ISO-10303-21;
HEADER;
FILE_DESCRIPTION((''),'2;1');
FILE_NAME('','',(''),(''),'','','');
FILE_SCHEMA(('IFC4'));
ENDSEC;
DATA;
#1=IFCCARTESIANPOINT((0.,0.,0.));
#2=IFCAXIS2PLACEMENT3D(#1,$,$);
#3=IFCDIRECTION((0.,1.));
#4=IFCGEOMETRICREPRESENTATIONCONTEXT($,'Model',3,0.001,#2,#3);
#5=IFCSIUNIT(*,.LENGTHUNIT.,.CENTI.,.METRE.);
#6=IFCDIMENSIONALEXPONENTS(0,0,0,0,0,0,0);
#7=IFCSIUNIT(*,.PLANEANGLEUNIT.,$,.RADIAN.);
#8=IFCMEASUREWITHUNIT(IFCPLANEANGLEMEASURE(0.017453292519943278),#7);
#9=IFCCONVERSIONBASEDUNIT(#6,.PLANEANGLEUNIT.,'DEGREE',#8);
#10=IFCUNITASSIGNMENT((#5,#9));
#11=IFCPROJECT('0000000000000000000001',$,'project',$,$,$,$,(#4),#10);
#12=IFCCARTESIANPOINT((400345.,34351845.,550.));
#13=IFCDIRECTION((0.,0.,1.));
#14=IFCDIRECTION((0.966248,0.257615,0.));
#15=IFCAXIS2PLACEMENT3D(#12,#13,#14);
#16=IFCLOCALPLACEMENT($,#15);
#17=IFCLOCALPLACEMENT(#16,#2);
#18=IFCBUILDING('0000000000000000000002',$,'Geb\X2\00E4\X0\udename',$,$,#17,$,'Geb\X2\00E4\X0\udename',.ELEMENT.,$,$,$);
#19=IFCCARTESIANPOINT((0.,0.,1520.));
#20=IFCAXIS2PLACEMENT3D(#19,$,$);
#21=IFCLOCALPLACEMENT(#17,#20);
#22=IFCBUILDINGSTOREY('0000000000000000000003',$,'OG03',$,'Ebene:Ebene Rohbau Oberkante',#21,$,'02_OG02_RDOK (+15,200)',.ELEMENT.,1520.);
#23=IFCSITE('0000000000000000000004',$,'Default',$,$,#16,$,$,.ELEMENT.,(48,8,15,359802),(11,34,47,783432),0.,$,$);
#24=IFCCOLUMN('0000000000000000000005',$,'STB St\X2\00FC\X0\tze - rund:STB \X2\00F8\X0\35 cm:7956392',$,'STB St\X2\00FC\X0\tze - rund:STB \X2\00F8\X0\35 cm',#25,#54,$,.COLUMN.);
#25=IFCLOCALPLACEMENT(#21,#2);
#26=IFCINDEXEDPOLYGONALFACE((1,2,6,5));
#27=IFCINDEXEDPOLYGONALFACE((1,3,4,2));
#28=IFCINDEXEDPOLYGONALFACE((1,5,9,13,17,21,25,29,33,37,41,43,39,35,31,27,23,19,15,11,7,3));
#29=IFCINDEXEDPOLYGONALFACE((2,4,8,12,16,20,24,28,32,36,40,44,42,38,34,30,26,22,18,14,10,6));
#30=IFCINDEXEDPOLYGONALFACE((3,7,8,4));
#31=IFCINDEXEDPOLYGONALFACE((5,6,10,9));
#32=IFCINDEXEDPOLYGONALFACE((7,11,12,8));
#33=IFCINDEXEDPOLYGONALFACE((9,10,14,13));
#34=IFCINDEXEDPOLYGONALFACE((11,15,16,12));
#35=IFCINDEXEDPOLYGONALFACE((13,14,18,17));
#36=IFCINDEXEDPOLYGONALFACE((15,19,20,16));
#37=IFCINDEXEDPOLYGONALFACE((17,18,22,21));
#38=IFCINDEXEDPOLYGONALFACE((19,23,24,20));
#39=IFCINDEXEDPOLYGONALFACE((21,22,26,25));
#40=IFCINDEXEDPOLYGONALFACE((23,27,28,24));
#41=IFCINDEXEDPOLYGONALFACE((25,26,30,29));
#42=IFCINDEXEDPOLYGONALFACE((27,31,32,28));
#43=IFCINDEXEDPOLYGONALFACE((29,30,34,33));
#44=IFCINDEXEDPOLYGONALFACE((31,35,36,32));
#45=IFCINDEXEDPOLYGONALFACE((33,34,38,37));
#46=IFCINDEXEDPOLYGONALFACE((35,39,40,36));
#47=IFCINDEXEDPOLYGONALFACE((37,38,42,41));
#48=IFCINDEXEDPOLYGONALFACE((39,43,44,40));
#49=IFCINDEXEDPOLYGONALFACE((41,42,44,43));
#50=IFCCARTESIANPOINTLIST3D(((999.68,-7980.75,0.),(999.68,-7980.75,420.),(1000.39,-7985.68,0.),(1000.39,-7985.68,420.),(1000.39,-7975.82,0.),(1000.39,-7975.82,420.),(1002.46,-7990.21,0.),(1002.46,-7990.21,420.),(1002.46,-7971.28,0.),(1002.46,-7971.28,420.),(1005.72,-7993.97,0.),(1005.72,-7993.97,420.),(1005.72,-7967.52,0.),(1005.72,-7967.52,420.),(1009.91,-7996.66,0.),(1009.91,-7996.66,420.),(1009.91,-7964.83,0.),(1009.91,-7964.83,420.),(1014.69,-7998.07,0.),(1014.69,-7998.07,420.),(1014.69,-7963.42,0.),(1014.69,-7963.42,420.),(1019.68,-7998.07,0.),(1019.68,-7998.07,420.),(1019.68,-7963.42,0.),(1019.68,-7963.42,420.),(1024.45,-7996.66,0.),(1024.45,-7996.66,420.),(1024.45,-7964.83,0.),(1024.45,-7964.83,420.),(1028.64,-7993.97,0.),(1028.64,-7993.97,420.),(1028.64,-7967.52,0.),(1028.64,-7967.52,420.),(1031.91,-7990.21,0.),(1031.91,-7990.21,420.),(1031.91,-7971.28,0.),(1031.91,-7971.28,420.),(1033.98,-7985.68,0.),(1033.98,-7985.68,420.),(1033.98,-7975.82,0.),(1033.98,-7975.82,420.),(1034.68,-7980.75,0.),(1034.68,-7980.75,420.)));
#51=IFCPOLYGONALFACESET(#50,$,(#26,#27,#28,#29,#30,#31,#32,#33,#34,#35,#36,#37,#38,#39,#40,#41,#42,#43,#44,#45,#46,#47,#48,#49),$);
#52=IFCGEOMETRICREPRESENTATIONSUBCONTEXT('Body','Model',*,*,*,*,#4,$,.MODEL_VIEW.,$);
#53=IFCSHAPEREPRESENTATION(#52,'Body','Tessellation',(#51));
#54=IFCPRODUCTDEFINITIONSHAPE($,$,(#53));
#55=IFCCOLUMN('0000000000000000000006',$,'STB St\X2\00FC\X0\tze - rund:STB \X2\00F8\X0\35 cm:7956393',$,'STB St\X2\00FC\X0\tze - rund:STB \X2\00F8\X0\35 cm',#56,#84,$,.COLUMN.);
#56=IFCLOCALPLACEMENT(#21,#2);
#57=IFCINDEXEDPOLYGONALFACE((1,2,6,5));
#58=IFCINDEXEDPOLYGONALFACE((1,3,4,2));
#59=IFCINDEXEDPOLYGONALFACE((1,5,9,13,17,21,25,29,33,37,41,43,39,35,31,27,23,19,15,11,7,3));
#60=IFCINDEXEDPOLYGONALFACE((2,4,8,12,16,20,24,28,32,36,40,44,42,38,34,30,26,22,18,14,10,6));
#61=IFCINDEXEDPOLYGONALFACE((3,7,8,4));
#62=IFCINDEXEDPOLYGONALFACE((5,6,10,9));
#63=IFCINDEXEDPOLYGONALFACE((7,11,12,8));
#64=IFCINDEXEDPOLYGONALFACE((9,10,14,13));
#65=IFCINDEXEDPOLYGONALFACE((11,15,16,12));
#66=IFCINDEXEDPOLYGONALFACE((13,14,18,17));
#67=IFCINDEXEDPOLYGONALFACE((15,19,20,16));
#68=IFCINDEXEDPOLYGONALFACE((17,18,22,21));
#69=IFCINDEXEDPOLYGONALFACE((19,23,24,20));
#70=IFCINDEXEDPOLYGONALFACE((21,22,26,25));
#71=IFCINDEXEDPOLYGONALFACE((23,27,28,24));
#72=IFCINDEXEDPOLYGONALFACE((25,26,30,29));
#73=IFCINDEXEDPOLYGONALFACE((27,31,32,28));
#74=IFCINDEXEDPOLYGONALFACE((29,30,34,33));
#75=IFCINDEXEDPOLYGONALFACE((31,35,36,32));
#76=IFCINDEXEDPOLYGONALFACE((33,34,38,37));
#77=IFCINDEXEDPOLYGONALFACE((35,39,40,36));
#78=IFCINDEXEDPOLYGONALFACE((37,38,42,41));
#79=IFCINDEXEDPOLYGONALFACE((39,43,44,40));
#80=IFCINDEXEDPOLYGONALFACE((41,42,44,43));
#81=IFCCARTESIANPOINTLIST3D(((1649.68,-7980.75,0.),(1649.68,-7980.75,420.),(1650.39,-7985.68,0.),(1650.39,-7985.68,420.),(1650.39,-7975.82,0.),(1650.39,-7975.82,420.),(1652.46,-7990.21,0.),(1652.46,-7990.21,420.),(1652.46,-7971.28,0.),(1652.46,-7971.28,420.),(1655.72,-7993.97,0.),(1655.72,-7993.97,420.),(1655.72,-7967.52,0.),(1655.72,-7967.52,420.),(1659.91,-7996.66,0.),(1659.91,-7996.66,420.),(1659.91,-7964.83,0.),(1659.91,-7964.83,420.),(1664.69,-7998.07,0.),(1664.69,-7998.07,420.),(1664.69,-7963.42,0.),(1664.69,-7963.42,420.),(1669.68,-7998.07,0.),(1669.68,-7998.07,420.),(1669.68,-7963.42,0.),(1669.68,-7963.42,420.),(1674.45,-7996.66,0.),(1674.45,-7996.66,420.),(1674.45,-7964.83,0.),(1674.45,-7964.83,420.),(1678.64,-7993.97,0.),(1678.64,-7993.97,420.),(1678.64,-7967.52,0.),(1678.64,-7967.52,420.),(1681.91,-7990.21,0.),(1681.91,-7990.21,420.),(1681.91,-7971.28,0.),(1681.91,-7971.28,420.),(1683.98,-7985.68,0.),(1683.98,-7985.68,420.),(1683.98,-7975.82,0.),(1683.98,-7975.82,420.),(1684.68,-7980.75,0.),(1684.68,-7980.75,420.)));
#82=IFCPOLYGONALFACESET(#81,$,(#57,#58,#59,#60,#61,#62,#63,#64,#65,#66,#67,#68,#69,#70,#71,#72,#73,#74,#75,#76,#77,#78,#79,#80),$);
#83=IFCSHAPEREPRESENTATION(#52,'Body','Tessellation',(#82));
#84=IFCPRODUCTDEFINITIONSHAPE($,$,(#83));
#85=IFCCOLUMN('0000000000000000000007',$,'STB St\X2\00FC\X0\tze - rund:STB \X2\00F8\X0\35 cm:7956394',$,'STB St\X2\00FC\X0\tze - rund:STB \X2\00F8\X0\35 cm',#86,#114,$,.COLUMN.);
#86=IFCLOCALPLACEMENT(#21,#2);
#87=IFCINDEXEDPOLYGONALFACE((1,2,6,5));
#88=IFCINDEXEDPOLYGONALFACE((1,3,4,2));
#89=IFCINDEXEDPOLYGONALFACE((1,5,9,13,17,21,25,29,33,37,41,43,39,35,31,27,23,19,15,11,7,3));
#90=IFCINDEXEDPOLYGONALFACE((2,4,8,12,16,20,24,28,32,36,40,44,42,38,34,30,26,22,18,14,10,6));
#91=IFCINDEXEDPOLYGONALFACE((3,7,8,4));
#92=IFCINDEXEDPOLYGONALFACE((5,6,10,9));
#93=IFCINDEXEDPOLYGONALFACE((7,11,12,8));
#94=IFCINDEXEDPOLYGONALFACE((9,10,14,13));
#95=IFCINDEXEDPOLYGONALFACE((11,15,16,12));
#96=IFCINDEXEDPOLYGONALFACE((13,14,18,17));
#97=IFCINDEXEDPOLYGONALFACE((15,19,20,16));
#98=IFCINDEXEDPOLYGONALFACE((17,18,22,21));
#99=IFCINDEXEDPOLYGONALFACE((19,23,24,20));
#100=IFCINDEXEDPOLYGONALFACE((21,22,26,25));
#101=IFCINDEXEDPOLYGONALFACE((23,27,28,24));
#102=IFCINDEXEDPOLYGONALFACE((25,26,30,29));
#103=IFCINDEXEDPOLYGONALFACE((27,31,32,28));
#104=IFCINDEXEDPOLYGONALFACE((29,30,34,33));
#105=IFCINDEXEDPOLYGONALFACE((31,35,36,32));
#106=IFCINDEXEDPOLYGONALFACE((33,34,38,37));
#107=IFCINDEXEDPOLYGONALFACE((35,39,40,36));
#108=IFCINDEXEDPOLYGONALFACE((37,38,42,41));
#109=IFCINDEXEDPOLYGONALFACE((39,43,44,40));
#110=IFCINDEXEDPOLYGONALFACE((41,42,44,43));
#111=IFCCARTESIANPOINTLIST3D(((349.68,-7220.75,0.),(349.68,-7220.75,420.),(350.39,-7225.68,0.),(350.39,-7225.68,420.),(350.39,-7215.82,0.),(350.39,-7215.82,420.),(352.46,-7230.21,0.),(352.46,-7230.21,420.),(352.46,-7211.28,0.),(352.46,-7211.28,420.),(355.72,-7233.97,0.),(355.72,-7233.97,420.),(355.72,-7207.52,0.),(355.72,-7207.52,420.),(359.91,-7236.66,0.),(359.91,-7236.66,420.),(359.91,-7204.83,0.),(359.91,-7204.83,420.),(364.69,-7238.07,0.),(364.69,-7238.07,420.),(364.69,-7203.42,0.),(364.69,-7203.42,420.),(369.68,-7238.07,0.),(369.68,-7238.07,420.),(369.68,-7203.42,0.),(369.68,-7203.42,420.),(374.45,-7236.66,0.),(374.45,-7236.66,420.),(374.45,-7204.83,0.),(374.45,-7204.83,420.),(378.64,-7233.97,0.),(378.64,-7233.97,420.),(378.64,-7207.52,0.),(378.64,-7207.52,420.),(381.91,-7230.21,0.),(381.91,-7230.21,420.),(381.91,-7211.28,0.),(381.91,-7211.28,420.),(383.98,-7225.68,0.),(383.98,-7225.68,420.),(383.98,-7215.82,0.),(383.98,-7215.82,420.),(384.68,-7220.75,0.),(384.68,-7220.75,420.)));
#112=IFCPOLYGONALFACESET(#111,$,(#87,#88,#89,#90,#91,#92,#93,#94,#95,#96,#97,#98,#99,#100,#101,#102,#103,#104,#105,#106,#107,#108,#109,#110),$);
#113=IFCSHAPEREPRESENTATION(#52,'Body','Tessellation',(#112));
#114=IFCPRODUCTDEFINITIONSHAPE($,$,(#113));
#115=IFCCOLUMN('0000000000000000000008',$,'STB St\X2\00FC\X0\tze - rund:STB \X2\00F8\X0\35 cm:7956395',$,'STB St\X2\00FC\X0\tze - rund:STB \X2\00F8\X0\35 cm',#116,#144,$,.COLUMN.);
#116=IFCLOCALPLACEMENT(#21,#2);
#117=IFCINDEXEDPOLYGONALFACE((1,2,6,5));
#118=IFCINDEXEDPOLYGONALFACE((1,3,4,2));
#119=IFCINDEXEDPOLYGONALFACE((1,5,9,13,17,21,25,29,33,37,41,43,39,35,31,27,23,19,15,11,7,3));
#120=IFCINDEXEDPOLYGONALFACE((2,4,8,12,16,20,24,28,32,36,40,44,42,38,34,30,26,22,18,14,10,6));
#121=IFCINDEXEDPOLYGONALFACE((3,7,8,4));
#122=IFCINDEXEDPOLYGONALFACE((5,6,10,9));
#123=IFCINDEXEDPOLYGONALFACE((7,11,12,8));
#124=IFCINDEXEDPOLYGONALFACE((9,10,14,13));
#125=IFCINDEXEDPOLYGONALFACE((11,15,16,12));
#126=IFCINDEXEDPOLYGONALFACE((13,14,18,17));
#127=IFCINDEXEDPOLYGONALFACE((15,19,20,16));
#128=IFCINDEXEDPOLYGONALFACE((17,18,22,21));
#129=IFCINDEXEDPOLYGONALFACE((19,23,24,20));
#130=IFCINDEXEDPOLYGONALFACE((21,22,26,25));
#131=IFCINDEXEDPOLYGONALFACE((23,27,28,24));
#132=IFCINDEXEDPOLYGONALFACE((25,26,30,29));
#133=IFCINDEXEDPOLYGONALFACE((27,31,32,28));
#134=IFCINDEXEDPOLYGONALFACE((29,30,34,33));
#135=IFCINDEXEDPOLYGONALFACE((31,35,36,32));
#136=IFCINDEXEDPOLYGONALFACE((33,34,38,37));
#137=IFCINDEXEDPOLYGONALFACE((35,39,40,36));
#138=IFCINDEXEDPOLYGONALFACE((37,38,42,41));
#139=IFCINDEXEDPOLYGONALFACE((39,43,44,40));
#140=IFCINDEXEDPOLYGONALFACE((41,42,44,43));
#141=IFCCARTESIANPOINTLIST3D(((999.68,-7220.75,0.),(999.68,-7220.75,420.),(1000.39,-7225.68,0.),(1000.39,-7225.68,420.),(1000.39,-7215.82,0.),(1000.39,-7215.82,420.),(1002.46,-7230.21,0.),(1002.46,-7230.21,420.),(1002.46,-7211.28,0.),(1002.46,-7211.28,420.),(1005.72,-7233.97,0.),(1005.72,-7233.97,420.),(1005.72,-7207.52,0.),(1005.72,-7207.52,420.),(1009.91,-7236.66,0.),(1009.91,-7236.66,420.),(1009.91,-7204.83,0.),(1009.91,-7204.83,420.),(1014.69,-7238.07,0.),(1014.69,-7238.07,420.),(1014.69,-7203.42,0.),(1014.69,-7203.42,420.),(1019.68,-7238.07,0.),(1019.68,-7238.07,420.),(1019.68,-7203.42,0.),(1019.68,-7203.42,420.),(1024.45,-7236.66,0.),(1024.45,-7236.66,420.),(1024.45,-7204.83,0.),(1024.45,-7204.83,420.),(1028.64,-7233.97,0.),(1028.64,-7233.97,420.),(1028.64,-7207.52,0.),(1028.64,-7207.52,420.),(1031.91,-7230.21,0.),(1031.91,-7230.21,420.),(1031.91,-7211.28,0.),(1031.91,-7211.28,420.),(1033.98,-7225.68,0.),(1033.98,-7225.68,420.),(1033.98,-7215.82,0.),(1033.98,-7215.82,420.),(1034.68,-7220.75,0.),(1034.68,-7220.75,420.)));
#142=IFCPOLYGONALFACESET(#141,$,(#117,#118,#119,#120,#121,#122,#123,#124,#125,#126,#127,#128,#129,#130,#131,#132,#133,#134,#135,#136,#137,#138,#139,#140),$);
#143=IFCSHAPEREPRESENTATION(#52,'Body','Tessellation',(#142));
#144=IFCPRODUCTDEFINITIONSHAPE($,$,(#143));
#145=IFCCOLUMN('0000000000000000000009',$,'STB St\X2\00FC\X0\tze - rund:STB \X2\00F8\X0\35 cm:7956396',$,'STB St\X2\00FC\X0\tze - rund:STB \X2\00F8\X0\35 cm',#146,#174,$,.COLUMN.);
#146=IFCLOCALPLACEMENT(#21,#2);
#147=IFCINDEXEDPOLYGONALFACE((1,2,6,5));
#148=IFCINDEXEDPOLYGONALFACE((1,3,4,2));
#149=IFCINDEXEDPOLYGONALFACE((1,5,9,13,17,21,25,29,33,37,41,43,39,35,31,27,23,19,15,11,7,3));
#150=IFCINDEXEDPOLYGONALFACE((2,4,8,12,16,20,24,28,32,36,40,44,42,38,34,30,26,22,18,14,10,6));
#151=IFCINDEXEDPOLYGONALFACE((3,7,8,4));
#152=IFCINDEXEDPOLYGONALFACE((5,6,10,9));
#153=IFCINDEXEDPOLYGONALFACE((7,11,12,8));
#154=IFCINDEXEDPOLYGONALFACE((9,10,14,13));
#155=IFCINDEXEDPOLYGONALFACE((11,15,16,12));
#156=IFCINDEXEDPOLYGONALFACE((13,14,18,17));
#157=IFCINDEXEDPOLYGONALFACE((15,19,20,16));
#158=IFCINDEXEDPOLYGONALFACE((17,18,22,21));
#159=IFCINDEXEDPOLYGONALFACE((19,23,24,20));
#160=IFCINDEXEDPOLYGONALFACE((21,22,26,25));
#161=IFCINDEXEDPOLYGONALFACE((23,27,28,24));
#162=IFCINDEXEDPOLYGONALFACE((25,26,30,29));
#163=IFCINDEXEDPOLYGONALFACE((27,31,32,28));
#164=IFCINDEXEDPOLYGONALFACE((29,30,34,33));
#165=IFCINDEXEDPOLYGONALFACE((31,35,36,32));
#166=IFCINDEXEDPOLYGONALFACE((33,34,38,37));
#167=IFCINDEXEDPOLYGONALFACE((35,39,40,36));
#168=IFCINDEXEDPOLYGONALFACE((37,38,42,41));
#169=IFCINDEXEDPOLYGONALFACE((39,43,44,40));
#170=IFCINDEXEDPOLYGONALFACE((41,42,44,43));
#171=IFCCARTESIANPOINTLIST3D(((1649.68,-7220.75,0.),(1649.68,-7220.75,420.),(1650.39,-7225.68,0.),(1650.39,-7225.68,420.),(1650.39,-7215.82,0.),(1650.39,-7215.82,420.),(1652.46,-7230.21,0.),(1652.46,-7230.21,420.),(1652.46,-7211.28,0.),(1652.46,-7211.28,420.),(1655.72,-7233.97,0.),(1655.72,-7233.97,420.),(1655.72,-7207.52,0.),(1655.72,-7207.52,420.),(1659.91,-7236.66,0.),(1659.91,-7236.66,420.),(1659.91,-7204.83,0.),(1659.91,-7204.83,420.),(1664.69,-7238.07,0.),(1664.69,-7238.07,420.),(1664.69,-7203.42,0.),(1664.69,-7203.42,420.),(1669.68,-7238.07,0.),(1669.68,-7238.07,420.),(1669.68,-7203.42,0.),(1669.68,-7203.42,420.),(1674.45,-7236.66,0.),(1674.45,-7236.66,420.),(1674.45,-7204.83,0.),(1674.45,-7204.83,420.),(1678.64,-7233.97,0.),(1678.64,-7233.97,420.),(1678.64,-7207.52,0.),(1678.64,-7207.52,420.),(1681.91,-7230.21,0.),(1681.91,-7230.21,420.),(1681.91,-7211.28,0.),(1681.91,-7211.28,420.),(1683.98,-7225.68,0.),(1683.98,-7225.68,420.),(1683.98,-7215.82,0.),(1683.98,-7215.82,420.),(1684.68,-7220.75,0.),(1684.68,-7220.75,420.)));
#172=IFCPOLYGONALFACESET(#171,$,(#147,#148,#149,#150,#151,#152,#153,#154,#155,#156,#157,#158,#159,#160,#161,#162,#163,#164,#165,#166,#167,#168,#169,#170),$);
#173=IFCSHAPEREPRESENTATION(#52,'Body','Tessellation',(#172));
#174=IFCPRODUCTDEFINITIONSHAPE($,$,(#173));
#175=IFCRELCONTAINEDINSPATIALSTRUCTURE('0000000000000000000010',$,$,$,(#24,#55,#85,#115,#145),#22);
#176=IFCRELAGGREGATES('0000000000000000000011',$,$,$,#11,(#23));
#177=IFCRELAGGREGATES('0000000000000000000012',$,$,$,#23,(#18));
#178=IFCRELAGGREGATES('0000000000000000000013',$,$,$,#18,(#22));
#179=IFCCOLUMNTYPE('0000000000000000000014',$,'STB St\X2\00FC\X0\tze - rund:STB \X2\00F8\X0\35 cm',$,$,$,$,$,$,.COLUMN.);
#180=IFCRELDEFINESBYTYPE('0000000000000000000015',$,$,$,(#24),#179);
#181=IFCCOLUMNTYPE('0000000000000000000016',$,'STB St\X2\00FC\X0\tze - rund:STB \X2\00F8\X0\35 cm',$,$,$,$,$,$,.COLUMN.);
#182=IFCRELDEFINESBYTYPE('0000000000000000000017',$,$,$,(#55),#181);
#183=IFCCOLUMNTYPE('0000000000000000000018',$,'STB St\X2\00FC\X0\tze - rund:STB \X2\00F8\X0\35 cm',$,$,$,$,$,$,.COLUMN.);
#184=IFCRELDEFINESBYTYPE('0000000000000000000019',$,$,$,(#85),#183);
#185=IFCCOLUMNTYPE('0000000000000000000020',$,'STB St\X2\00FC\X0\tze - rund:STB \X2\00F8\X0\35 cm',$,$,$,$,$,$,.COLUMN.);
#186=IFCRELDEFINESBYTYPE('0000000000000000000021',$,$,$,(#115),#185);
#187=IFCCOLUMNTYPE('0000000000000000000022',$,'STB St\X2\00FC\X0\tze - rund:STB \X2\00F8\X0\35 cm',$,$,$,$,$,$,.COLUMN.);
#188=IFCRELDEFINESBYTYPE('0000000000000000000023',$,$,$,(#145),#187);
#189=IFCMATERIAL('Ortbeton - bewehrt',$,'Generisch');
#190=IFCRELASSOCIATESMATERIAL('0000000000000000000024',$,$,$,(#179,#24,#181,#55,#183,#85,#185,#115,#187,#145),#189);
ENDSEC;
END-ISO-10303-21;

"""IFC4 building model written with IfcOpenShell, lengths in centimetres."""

from ifc_helpers import new_model, entity, si_unit, converted_unit, direction, frame, origin, place, context, subcontext, project, spatial, arc, indexed_curve, outline, extrude, source, transform, mapped, material, type_object, type_shapes, element, save


model = new_model("IFC4")

# Units and contexts
model_context = context("Model", 3, precision=0.001, world=origin(), true_north=direction((0.0, 1.0)))
body_context = subcontext(model_context, "Body", "Model", "MODEL_VIEW")
ifc_project = project(units=[si_unit("LENGTHUNIT", "METRE", prefix="CENTI"), converted_unit("PLANEANGLEUNIT", "DEGREE", entity("IfcPlaneAngleMeasure", 0.017453292519943278), si_unit("PLANEANGLEUNIT", "RADIAN"), dimensions=[0, 0, 0, 0, 0, 0, 0])], contexts=[model_context])

# Site, building, storey
site_placement = place(None, frame((400345.0, 34351845.0, 550.0), z_axis=(0.0, 0.0, 1.0), x_axis=(0.966248, 0.257615, 0.0)))
site = spatial("IfcSite", under=ifc_project, at=site_placement, Name="Default", CompositionType="ELEMENT", RefLatitude=(48, 8, 15, 359802), RefLongitude=(11, 34, 47, 783432), RefElevation=0.0)
building_placement = place(site_placement, origin())
building = spatial("IfcBuilding", under=site, at=building_placement, Name="Gebäudename", LongName="Gebäudename", CompositionType="ELEMENT")
storey_placement = place(building_placement, frame((0.0, 0.0, 1520.0)))
storey = spatial("IfcBuildingStorey", under=building, at=storey_placement, Name="OG03", ObjectType="Ebene:Ebene Rohbau Oberkante", LongName="02_OG02_RDOK (+15,200)", CompositionType="ELEMENT", Elevation=1520.0)

# Columns
ifc_material = material(Name="Ortbeton - bewehrt", Category="Generisch")
column_type_1 = type_object("IfcColumnType", Name="STB Stütze - rund:STB ø35 cm", PredefinedType="COLUMN", material=ifc_material)
shared_shape_1 = source(origin(), body_context, "Body", "SweptSolid", [
    extrude(outline(indexed_curve([(-17.5, 0.0), (0.0, -17.5), (17.5, 0.0), (0.0, 17.5)], segments=[arc(1, 2, 3), arc(3, 4, 1)], self_intersect=False)), frame((1017.18, -7980.75, 1520.0)), (0.0, 0.0, 1.0), 420.0),
])
type_shapes(column_type_1, [shared_shape_1])
column_1_placement = place(storey_placement, frame((0.0, 0.0, -1520.0)))
element("IfcColumn", 1, at=column_1_placement, inside=storey, type_object=column_type_1, material=ifc_material, Name="STB Stütze - rund:STB ø35 cm:7956392", ObjectType="STB Stütze - rund:STB ø35 cm", PredefinedType="COLUMN", context=body_context, shape_type="MappedRepresentation", body=[
    mapped(shared_shape_1, transform((0.0, 0.0, 0.0), scale=1.0)),
])
column_type_2 = type_object("IfcColumnType", Name="STB Stütze - rund:STB ø35 cm", PredefinedType="COLUMN", material=ifc_material)
shared_shape_2 = source(origin(), body_context, "Body", "SweptSolid", [
    extrude(outline(indexed_curve([(-17.5, 0.0), (0.0, -17.5), (17.5, 0.0), (0.0, 17.5)], segments=[arc(1, 2, 3), arc(3, 4, 1)], self_intersect=False)), frame((1667.18, -7980.75, 1520.0)), (0.0, 0.0, 1.0), 420.0),
])
type_shapes(column_type_2, [shared_shape_2])
column_2_placement = place(storey_placement, frame((0.0, 0.0, -1520.0)))
element("IfcColumn", 2, at=column_2_placement, inside=storey, type_object=column_type_2, material=ifc_material, Name="STB Stütze - rund:STB ø35 cm:7956393", ObjectType="STB Stütze - rund:STB ø35 cm", PredefinedType="COLUMN", context=body_context, shape_type="MappedRepresentation", body=[
    mapped(shared_shape_2, transform((0.0, 0.0, 0.0), scale=1.0)),
])
column_type_3 = type_object("IfcColumnType", Name="STB Stütze - rund:STB ø35 cm", PredefinedType="COLUMN", material=ifc_material)
shared_shape_3 = source(origin(), body_context, "Body", "SweptSolid", [
    extrude(outline(indexed_curve([(-17.5, 0.0), (0.0, -17.5), (17.5, 0.0), (0.0, 17.5)], segments=[arc(1, 2, 3), arc(3, 4, 1)], self_intersect=False)), frame((367.18, -7220.75, 1520.0)), (0.0, 0.0, 1.0), 420.0),
])
type_shapes(column_type_3, [shared_shape_3])
column_3_placement = place(storey_placement, frame((0.0, 0.0, -1520.0)))
element("IfcColumn", 3, at=column_3_placement, inside=storey, type_object=column_type_3, material=ifc_material, Name="STB Stütze - rund:STB ø35 cm:7956394", ObjectType="STB Stütze - rund:STB ø35 cm", PredefinedType="COLUMN", context=body_context, shape_type="MappedRepresentation", body=[
    mapped(shared_shape_3, transform((0.0, 0.0, 0.0), scale=1.0)),
])
column_type_4 = type_object("IfcColumnType", Name="STB Stütze - rund:STB ø35 cm", PredefinedType="COLUMN", material=ifc_material)
shared_shape_4 = source(origin(), body_context, "Body", "SweptSolid", [
    extrude(outline(indexed_curve([(-17.5, 0.0), (0.0, -17.5), (17.5, 0.0), (0.0, 17.5)], segments=[arc(1, 2, 3), arc(3, 4, 1)], self_intersect=False)), frame((1017.18, -7220.75, 1520.0)), (0.0, 0.0, 1.0), 420.0),
])
type_shapes(column_type_4, [shared_shape_4])
column_4_placement = place(storey_placement, frame((0.0, 0.0, -1520.0)))
element("IfcColumn", 4, at=column_4_placement, inside=storey, type_object=column_type_4, material=ifc_material, Name="STB Stütze - rund:STB ø35 cm:7956395", ObjectType="STB Stütze - rund:STB ø35 cm", PredefinedType="COLUMN", context=body_context, shape_type="MappedRepresentation", body=[
    mapped(shared_shape_4, transform((0.0, 0.0, 0.0), scale=1.0)),
])
column_type_5 = type_object("IfcColumnType", Name="STB Stütze - rund:STB ø35 cm", PredefinedType="COLUMN", material=ifc_material)
shared_shape_5 = source(origin(), body_context, "Body", "SweptSolid", [
    extrude(outline(indexed_curve([(-17.5, 0.0), (0.0, -17.5), (17.5, 0.0), (0.0, 17.5)], segments=[arc(1, 2, 3), arc(3, 4, 1)], self_intersect=False)), frame((1667.18, -7220.75, 1520.0)), (0.0, 0.0, 1.0), 420.0),
])
type_shapes(column_type_5, [shared_shape_5])
column_5_placement = place(storey_placement, frame((0.0, 0.0, -1520.0)))
element("IfcColumn", 5, at=column_5_placement, inside=storey, type_object=column_type_5, material=ifc_material, Name="STB Stütze - rund:STB ø35 cm:7956396", ObjectType="STB Stütze - rund:STB ø35 cm", PredefinedType="COLUMN", context=body_context, shape_type="MappedRepresentation", body=[
    mapped(shared_shape_5, transform((0.0, 0.0, 0.0), scale=1.0)),
])

save(model, "model.ifc")
